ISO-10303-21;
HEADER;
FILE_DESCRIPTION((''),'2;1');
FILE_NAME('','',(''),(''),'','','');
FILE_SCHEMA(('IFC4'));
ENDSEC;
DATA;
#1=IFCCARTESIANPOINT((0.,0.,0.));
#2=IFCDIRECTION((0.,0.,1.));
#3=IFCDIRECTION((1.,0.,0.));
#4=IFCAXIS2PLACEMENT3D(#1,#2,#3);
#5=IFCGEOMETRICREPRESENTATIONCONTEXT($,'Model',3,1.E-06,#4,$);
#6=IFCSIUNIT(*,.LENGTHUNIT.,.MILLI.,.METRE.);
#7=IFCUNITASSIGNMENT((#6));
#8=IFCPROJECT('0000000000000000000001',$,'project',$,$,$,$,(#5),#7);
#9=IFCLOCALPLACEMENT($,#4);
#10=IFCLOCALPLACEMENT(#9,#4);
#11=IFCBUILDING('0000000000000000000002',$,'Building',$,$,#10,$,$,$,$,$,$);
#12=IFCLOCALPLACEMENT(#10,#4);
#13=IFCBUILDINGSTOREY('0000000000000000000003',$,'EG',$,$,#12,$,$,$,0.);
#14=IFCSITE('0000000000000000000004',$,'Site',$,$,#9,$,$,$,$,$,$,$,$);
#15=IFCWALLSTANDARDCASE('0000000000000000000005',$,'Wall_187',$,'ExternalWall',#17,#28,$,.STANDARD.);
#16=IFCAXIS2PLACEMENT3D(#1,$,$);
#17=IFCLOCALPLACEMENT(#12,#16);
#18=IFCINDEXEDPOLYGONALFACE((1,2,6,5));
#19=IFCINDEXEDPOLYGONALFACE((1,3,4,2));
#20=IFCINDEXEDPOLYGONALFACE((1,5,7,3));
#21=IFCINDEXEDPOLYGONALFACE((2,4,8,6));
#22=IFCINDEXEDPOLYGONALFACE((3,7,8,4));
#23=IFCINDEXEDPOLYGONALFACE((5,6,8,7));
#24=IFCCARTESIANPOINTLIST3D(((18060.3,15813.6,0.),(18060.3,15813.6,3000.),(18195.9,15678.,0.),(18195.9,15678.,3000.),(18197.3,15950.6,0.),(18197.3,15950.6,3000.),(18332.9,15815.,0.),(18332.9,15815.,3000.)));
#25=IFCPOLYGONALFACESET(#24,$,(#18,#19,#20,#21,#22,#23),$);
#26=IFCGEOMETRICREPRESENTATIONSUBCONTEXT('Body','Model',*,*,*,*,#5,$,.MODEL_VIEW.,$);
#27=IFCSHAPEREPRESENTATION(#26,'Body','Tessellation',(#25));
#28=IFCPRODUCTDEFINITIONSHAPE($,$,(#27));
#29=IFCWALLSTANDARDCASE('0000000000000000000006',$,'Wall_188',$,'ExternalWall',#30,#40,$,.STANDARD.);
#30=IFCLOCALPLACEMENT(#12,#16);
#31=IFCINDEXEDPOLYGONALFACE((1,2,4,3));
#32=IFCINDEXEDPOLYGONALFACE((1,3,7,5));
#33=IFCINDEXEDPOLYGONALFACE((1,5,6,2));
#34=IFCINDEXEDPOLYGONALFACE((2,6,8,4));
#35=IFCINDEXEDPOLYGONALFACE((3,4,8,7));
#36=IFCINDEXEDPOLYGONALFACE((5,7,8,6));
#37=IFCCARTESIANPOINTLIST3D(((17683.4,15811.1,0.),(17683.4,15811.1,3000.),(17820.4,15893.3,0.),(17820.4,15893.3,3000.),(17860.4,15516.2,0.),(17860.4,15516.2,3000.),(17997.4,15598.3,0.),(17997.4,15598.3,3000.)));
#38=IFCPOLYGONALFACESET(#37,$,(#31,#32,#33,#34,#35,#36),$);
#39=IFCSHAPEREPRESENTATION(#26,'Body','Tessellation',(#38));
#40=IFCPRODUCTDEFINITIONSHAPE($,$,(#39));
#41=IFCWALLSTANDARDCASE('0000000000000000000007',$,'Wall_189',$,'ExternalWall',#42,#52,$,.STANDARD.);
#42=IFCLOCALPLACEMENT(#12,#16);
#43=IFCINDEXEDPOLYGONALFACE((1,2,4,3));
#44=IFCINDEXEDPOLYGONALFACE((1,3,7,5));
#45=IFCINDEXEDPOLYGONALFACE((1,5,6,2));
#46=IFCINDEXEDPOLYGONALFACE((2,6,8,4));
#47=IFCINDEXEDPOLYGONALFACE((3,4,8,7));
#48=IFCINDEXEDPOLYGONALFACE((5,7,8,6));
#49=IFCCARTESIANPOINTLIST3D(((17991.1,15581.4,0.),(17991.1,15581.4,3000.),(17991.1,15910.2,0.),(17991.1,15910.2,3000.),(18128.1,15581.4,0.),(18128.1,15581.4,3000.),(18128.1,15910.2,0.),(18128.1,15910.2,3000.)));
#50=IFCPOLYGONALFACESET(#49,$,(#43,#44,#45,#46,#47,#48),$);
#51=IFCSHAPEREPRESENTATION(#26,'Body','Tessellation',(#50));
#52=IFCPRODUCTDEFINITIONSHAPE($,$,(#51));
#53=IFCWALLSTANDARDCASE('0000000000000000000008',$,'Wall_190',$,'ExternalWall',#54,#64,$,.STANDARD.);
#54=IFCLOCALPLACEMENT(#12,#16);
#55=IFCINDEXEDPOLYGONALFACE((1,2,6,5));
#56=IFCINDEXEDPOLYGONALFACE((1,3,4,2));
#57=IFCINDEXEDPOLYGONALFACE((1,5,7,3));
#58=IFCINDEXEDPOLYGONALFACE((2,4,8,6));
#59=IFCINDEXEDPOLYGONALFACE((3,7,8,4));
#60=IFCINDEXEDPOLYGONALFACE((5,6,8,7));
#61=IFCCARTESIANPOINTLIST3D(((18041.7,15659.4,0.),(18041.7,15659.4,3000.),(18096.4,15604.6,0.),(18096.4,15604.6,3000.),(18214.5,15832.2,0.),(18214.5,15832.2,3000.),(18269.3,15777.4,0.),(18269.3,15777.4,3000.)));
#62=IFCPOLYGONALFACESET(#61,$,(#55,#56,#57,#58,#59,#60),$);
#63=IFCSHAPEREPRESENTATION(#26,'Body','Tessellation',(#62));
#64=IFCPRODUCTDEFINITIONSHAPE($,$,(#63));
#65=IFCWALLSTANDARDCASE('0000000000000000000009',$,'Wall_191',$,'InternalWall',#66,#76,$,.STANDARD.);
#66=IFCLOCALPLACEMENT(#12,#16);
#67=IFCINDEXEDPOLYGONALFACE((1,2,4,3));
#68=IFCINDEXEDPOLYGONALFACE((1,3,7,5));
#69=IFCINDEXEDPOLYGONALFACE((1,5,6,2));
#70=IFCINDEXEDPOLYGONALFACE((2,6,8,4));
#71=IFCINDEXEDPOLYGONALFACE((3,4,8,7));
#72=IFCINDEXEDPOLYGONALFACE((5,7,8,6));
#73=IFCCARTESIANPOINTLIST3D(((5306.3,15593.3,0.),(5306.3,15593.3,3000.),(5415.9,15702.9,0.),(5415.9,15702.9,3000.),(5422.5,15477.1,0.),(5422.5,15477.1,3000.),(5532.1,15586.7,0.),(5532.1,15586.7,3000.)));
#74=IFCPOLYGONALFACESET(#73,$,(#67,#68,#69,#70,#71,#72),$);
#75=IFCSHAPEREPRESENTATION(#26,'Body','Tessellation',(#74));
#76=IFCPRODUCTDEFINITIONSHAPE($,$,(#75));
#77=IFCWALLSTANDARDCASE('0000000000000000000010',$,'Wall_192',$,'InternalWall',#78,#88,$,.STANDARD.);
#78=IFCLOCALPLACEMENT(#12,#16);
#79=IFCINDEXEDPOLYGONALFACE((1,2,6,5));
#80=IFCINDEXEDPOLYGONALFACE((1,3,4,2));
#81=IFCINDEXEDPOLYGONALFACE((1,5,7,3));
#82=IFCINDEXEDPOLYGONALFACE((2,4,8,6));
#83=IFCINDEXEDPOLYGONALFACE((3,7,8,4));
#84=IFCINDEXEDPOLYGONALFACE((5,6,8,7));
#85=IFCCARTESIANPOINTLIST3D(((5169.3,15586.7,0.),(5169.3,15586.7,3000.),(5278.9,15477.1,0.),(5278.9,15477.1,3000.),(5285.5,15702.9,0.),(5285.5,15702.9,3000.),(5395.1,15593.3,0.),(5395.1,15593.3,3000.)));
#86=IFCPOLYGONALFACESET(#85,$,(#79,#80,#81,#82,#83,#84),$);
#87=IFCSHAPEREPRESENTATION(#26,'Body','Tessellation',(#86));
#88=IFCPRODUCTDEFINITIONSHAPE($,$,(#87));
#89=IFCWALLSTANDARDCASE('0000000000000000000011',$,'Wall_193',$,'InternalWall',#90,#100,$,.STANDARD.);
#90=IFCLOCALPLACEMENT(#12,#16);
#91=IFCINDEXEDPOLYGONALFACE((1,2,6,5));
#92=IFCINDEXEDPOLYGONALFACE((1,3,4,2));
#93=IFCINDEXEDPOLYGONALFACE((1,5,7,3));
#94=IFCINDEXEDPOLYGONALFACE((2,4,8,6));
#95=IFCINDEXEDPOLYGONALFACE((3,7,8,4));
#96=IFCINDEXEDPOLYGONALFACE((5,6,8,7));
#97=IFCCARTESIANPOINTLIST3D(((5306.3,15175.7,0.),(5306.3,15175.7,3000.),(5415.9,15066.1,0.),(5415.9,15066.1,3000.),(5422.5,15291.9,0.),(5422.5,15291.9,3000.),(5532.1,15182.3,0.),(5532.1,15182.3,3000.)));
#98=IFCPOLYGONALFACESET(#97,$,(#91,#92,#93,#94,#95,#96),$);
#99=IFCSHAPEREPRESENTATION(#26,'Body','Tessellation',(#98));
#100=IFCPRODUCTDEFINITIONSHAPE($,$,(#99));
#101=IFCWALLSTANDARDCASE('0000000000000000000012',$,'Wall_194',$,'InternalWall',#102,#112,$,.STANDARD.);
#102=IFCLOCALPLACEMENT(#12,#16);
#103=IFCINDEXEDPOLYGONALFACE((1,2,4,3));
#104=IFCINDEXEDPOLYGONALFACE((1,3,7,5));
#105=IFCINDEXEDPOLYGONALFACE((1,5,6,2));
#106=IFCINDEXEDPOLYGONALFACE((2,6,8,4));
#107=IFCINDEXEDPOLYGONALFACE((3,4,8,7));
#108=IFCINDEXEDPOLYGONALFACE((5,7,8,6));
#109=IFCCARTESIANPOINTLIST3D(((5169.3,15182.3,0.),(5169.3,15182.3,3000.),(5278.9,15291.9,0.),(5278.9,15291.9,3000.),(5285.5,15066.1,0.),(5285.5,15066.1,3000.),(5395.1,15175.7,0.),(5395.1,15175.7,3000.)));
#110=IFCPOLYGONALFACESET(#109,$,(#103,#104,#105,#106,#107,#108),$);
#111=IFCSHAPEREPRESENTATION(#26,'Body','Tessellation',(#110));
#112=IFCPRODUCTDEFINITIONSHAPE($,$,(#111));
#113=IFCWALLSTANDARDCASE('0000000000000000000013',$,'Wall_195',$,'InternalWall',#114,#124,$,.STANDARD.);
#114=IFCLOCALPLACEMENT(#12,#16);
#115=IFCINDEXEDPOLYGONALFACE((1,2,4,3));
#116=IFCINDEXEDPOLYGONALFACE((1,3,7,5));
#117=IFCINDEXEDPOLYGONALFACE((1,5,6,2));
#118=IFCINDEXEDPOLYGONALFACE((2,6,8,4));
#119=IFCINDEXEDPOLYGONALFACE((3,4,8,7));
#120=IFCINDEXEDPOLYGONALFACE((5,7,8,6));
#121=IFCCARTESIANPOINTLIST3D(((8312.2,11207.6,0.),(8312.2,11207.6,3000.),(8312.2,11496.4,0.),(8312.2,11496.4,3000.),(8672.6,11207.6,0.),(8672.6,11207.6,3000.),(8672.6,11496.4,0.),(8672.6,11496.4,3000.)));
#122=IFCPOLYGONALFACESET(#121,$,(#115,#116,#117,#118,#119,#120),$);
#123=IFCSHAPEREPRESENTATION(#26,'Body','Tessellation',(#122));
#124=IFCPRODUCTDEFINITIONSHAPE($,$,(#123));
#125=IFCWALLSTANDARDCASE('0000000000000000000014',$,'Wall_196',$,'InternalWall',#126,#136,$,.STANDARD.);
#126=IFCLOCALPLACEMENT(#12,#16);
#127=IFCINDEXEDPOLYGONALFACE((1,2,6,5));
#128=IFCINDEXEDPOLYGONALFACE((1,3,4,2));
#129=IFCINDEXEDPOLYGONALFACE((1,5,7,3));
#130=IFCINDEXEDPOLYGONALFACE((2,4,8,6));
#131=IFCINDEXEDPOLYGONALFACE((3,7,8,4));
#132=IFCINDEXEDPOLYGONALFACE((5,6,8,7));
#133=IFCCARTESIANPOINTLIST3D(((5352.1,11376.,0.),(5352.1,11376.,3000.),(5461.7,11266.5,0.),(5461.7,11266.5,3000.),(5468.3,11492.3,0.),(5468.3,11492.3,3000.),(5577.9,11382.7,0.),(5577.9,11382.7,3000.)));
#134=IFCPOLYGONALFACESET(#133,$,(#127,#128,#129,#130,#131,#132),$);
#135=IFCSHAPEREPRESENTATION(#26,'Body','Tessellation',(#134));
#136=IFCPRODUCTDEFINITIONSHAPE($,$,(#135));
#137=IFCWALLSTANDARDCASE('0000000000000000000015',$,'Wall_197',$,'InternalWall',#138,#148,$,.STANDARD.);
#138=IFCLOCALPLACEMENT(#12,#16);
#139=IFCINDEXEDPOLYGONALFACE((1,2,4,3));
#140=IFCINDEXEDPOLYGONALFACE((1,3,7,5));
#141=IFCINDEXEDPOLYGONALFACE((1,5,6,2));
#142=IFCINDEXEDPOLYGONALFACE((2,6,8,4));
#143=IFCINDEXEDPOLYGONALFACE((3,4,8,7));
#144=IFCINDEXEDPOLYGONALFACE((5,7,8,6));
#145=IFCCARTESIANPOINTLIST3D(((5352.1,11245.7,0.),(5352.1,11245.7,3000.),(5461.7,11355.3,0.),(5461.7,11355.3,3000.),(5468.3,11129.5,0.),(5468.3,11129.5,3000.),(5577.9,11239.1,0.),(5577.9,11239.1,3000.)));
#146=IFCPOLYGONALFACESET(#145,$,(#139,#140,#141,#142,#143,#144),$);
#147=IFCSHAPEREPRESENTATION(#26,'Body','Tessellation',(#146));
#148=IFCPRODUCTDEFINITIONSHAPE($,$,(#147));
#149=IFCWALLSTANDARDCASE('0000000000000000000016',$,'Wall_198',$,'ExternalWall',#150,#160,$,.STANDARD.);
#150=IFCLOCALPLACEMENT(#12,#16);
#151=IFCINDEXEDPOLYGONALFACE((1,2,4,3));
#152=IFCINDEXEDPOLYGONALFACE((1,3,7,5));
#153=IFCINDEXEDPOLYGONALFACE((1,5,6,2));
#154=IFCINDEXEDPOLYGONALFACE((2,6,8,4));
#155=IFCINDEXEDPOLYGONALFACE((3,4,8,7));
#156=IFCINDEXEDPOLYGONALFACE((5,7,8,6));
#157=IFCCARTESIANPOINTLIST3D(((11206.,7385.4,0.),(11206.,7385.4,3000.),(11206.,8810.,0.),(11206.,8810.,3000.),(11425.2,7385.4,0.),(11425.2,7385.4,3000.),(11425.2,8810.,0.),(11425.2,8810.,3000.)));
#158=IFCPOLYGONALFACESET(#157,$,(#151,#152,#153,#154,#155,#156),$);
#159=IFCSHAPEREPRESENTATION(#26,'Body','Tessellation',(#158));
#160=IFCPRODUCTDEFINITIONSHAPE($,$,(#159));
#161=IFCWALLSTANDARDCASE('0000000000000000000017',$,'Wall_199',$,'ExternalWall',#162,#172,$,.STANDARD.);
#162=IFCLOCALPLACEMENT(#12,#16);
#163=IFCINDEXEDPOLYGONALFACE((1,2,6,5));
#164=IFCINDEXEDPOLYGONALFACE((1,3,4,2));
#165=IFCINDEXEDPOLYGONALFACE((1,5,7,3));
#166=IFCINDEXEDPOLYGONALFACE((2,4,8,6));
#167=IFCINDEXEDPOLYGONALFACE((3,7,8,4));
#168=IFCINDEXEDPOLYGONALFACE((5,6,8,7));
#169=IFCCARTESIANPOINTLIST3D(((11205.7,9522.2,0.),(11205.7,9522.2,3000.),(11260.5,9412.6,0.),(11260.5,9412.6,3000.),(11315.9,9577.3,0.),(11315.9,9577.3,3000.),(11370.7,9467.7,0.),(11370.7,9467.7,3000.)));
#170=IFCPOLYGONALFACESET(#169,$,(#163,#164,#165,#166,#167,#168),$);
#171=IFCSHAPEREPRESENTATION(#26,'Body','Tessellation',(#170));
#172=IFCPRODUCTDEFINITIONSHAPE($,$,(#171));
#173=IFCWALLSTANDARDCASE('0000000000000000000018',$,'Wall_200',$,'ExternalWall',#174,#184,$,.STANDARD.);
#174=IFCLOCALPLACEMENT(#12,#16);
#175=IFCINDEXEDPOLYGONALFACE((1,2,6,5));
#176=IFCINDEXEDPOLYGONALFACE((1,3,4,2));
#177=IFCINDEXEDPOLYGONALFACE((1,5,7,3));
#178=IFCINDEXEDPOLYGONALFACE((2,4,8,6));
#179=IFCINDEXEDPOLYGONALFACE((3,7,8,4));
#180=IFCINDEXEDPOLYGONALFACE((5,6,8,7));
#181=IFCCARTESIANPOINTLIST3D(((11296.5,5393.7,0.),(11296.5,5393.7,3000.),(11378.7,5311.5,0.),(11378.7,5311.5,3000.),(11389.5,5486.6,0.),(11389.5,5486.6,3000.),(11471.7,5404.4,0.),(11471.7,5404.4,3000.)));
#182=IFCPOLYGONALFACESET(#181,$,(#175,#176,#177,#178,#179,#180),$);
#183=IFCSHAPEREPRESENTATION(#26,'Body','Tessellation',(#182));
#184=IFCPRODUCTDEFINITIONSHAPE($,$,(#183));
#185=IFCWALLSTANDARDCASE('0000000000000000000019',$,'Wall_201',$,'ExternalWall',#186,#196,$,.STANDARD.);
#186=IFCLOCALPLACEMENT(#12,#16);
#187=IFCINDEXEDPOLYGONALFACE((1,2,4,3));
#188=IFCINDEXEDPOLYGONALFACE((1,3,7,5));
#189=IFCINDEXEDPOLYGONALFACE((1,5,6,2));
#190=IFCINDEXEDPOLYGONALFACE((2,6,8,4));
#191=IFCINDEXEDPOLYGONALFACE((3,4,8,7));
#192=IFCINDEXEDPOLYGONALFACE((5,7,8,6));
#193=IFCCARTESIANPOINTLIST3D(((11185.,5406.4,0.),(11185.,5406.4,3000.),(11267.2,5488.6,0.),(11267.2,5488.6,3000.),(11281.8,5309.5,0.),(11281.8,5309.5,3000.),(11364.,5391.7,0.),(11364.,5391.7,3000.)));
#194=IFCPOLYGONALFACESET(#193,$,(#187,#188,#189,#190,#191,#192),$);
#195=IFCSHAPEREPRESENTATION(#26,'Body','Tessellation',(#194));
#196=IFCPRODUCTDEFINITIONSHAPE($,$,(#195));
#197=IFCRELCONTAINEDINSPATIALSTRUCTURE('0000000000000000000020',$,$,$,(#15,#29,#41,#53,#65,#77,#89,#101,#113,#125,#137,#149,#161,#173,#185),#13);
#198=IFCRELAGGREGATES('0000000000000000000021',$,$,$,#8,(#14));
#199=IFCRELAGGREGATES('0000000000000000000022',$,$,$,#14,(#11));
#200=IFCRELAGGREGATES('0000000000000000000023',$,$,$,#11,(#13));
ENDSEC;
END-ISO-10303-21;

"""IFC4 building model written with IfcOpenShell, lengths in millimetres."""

from ifc_helpers import new_model, si_unit, frame, origin_with_axes, place, context, subcontext, project, spatial, rectangle, extrude, element, save


model = new_model("IFC4")

# Units and contexts
model_context = context("Model", 3, precision=1e-06, world=origin_with_axes())
body_context = subcontext(model_context, "Body", "Model", "MODEL_VIEW")
ifc_project = project(units=[si_unit("LENGTHUNIT", "METRE", prefix="MILLI")], contexts=[model_context])

# Site, building, storey
site_placement = place(None, origin_with_axes())
site = spatial("IfcSite", under=ifc_project, at=site_placement, Name="Site")
building_placement = place(site_placement, origin_with_axes())
building = spatial("IfcBuilding", under=site, at=building_placement, Name="Building")
storey_placement = place(building_placement, origin_with_axes())
storey = spatial("IfcBuildingStorey", under=building, at=storey_placement, Name="EG", Elevation=0.0)

# Walls
wall_1_placement = place(storey_placement, origin_with_axes())
element("IfcWallStandardCase", 1, at=wall_1_placement, inside=storey, Name="Wall_187", ObjectType="ExternalWall", PredefinedType="STANDARD", context=body_context, shape_type="SweptSolid", body=[
    extrude(rectangle(XDim=193.7, YDim=191.8), frame((18196.6, 15814.3, 0.0), z_axis=(0.0, 0.0, 1.0), x_axis=(0.707107, 0.707107, 0.0)), (0.0, 0.0, 1.0), 3000.0),
])
wall_2_placement = place(storey_placement, origin_with_axes())
element("IfcWallStandardCase", 2, at=wall_2_placement, inside=storey, Name="Wall_188", ObjectType="ExternalWall", PredefinedType="STANDARD", context=body_context, shape_type="SweptSolid", body=[
    extrude(rectangle(XDim=159.8, YDim=343.9), frame((17840.4, 15704.7, 0.0), z_axis=(0.0, 0.0, 1.0), x_axis=(0.857493, 0.514496, 0.0)), (0.0, 0.0, 1.0), 3000.0),
])
wall_3_placement = place(storey_placement, origin_with_axes())
element("IfcWallStandardCase", 3, at=wall_3_placement, inside=storey, Name="Wall_189", ObjectType="ExternalWall", PredefinedType="STANDARD", context=body_context, shape_type="SweptSolid", body=[
    extrude(rectangle(XDim=137.0, YDim=328.8), frame((18059.6, 15745.8, 0.0), z_axis=(0.0, 0.0, 1.0), x_axis=(1.0, 0.0, 0.0)), (0.0, 0.0, 1.0), 3000.0),
])
wall_4_placement = place(storey_placement, origin_with_axes())
element("IfcWallStandardCase", 4, at=wall_4_placement, inside=storey, Name="Wall_190", ObjectType="ExternalWall", PredefinedType="STANDARD", context=body_context, shape_type="SweptSolid", body=[
    extrude(rectangle(XDim=77.5, YDim=244.5), frame((18155.5, 15718.4, 0.0), z_axis=(0.0, 0.0, 1.0), x_axis=(0.707107, -0.707107, 0.0)), (0.0, 0.0, 1.0), 3000.0),
])
wall_5_placement = place(storey_placement, origin_with_axes())
element("IfcWallStandardCase", 5, at=wall_5_placement, inside=storey, Name="Wall_191", ObjectType="InternalWall", PredefinedType="STANDARD", context=body_context, shape_type="SweptSolid", body=[
    extrude(rectangle(XDim=155.0, YDim=164.4), frame((5419.2, 15590.0, 0.0), z_axis=(0.0, 0.0, 1.0), x_axis=(0.707107, 0.707107, 0.0)), (0.0, 0.0, 1.0), 3000.0),
])
wall_6_placement = place(storey_placement, origin_with_axes())
element("IfcWallStandardCase", 6, at=wall_6_placement, inside=storey, Name="Wall_192", ObjectType="InternalWall", PredefinedType="STANDARD", context=body_context, shape_type="SweptSolid", body=[
    extrude(rectangle(XDim=155.0, YDim=164.4), frame((5282.2, 15590.0, 0.0), z_axis=(0.0, 0.0, 1.0), x_axis=(-0.707107, 0.707107, 0.0)), (0.0, 0.0, 1.0), 3000.0),
])
wall_7_placement = place(storey_placement, origin_with_axes())
element("IfcWallStandardCase", 7, at=wall_7_placement, inside=storey, Name="Wall_193", ObjectType="InternalWall", PredefinedType="STANDARD", context=body_context, shape_type="SweptSolid", body=[
    extrude(rectangle(XDim=155.0, YDim=164.4), frame((5419.2, 15179.0, 0.0), z_axis=(0.0, 0.0, 1.0), x_axis=(0.707107, -0.707107, 0.0)), (0.0, 0.0, 1.0), 3000.0),
])
wall_8_placement = place(storey_placement, origin_with_axes())
element("IfcWallStandardCase", 8, at=wall_8_placement, inside=storey, Name="Wall_194", ObjectType="InternalWall", PredefinedType="STANDARD", context=body_context, shape_type="SweptSolid", body=[
    extrude(rectangle(XDim=155.0, YDim=164.4), frame((5282.2, 15179.0, 0.0), z_axis=(0.0, 0.0, 1.0), x_axis=(-0.707107, -0.707107, 0.0)), (0.0, 0.0, 1.0), 3000.0),
])
wall_9_placement = place(storey_placement, origin_with_axes())
element("IfcWallStandardCase", 9, at=wall_9_placement, inside=storey, Name="Wall_195", ObjectType="InternalWall", PredefinedType="STANDARD", context=body_context, shape_type="SweptSolid", body=[
    extrude(rectangle(XDim=360.4, YDim=288.8), frame((8492.4, 11352.0, 0.0), z_axis=(0.0, 0.0, 1.0), x_axis=(1.0, 0.0, 0.0)), (0.0, 0.0, 1.0), 3000.0),
])
wall_10_placement = place(storey_placement, origin_with_axes())
element("IfcWallStandardCase", 10, at=wall_10_placement, inside=storey, Name="Wall_196", ObjectType="InternalWall", PredefinedType="STANDARD", context=body_context, shape_type="SweptSolid", body=[
    extrude(rectangle(XDim=155.0, YDim=164.4), frame((5465.0, 11379.4, 0.0), z_axis=(0.0, 0.0, 1.0), x_axis=(-0.707107, 0.707107, 0.0)), (0.0, 0.0, 1.0), 3000.0),
])
wall_11_placement = place(storey_placement, origin_with_axes())
element("IfcWallStandardCase", 11, at=wall_11_placement, inside=storey, Name="Wall_197", ObjectType="InternalWall", PredefinedType="STANDARD", context=body_context, shape_type="SweptSolid", body=[
    extrude(rectangle(XDim=155.0, YDim=164.4), frame((5465.0, 11242.4, 0.0), z_axis=(0.0, 0.0, 1.0), x_axis=(-0.707107, -0.707107, 0.0)), (0.0, 0.0, 1.0), 3000.0),
])
wall_12_placement = place(storey_placement, origin_with_axes())
element("IfcWallStandardCase", 12, at=wall_12_placement, inside=storey, Name="Wall_198", ObjectType="ExternalWall", PredefinedType="STANDARD", context=body_context, shape_type="SweptSolid", body=[
    extrude(rectangle(XDim=1424.7, YDim=219.2), frame((11315.6, 8097.7, 0.0), z_axis=(0.0, 0.0, 1.0), x_axis=(0.0, 1.0, 0.0)), (0.0, 0.0, 1.0), 3000.0),
])
wall_13_placement = place(storey_placement, origin_with_axes())
element("IfcWallStandardCase", 13, at=wall_13_placement, inside=storey, Name="Wall_199", ObjectType="ExternalWall", PredefinedType="STANDARD", context=body_context, shape_type="SweptSolid", body=[
    extrude(rectangle(XDim=122.5, YDim=123.2), frame((11288.2, 9494.9, 0.0), z_axis=(0.0, 0.0, 1.0), x_axis=(-0.447214, 0.894427, 0.0)), (0.0, 0.0, 1.0), 3000.0),
])
wall_14_placement = place(storey_placement, origin_with_axes())
element("IfcWallStandardCase", 14, at=wall_14_placement, inside=storey, Name="Wall_200", ObjectType="ExternalWall", PredefinedType="STANDARD", context=body_context, shape_type="SweptSolid", body=[
    extrude(rectangle(XDim=116.2, YDim=131.5), frame((11384.1, 5399.1, 0.0), z_axis=(0.0, 0.0, 1.0), x_axis=(0.707107, -0.707107, 0.0)), (0.0, 0.0, 1.0), 3000.0),
])
wall_15_placement = place(storey_placement, origin_with_axes())
element("IfcWallStandardCase", 15, at=wall_15_placement, inside=storey, Name="Wall_201", ObjectType="ExternalWall", PredefinedType="STANDARD", context=body_context, shape_type="SweptSolid", body=[
    extrude(rectangle(XDim=116.2, YDim=137.0), frame((11274.5, 5399.1, 0.0), z_axis=(0.0, 0.0, 1.0), x_axis=(-0.707107, -0.707107, 0.0)), (0.0, 0.0, 1.0), 3000.0),
])

save(model, "model.ifc")
